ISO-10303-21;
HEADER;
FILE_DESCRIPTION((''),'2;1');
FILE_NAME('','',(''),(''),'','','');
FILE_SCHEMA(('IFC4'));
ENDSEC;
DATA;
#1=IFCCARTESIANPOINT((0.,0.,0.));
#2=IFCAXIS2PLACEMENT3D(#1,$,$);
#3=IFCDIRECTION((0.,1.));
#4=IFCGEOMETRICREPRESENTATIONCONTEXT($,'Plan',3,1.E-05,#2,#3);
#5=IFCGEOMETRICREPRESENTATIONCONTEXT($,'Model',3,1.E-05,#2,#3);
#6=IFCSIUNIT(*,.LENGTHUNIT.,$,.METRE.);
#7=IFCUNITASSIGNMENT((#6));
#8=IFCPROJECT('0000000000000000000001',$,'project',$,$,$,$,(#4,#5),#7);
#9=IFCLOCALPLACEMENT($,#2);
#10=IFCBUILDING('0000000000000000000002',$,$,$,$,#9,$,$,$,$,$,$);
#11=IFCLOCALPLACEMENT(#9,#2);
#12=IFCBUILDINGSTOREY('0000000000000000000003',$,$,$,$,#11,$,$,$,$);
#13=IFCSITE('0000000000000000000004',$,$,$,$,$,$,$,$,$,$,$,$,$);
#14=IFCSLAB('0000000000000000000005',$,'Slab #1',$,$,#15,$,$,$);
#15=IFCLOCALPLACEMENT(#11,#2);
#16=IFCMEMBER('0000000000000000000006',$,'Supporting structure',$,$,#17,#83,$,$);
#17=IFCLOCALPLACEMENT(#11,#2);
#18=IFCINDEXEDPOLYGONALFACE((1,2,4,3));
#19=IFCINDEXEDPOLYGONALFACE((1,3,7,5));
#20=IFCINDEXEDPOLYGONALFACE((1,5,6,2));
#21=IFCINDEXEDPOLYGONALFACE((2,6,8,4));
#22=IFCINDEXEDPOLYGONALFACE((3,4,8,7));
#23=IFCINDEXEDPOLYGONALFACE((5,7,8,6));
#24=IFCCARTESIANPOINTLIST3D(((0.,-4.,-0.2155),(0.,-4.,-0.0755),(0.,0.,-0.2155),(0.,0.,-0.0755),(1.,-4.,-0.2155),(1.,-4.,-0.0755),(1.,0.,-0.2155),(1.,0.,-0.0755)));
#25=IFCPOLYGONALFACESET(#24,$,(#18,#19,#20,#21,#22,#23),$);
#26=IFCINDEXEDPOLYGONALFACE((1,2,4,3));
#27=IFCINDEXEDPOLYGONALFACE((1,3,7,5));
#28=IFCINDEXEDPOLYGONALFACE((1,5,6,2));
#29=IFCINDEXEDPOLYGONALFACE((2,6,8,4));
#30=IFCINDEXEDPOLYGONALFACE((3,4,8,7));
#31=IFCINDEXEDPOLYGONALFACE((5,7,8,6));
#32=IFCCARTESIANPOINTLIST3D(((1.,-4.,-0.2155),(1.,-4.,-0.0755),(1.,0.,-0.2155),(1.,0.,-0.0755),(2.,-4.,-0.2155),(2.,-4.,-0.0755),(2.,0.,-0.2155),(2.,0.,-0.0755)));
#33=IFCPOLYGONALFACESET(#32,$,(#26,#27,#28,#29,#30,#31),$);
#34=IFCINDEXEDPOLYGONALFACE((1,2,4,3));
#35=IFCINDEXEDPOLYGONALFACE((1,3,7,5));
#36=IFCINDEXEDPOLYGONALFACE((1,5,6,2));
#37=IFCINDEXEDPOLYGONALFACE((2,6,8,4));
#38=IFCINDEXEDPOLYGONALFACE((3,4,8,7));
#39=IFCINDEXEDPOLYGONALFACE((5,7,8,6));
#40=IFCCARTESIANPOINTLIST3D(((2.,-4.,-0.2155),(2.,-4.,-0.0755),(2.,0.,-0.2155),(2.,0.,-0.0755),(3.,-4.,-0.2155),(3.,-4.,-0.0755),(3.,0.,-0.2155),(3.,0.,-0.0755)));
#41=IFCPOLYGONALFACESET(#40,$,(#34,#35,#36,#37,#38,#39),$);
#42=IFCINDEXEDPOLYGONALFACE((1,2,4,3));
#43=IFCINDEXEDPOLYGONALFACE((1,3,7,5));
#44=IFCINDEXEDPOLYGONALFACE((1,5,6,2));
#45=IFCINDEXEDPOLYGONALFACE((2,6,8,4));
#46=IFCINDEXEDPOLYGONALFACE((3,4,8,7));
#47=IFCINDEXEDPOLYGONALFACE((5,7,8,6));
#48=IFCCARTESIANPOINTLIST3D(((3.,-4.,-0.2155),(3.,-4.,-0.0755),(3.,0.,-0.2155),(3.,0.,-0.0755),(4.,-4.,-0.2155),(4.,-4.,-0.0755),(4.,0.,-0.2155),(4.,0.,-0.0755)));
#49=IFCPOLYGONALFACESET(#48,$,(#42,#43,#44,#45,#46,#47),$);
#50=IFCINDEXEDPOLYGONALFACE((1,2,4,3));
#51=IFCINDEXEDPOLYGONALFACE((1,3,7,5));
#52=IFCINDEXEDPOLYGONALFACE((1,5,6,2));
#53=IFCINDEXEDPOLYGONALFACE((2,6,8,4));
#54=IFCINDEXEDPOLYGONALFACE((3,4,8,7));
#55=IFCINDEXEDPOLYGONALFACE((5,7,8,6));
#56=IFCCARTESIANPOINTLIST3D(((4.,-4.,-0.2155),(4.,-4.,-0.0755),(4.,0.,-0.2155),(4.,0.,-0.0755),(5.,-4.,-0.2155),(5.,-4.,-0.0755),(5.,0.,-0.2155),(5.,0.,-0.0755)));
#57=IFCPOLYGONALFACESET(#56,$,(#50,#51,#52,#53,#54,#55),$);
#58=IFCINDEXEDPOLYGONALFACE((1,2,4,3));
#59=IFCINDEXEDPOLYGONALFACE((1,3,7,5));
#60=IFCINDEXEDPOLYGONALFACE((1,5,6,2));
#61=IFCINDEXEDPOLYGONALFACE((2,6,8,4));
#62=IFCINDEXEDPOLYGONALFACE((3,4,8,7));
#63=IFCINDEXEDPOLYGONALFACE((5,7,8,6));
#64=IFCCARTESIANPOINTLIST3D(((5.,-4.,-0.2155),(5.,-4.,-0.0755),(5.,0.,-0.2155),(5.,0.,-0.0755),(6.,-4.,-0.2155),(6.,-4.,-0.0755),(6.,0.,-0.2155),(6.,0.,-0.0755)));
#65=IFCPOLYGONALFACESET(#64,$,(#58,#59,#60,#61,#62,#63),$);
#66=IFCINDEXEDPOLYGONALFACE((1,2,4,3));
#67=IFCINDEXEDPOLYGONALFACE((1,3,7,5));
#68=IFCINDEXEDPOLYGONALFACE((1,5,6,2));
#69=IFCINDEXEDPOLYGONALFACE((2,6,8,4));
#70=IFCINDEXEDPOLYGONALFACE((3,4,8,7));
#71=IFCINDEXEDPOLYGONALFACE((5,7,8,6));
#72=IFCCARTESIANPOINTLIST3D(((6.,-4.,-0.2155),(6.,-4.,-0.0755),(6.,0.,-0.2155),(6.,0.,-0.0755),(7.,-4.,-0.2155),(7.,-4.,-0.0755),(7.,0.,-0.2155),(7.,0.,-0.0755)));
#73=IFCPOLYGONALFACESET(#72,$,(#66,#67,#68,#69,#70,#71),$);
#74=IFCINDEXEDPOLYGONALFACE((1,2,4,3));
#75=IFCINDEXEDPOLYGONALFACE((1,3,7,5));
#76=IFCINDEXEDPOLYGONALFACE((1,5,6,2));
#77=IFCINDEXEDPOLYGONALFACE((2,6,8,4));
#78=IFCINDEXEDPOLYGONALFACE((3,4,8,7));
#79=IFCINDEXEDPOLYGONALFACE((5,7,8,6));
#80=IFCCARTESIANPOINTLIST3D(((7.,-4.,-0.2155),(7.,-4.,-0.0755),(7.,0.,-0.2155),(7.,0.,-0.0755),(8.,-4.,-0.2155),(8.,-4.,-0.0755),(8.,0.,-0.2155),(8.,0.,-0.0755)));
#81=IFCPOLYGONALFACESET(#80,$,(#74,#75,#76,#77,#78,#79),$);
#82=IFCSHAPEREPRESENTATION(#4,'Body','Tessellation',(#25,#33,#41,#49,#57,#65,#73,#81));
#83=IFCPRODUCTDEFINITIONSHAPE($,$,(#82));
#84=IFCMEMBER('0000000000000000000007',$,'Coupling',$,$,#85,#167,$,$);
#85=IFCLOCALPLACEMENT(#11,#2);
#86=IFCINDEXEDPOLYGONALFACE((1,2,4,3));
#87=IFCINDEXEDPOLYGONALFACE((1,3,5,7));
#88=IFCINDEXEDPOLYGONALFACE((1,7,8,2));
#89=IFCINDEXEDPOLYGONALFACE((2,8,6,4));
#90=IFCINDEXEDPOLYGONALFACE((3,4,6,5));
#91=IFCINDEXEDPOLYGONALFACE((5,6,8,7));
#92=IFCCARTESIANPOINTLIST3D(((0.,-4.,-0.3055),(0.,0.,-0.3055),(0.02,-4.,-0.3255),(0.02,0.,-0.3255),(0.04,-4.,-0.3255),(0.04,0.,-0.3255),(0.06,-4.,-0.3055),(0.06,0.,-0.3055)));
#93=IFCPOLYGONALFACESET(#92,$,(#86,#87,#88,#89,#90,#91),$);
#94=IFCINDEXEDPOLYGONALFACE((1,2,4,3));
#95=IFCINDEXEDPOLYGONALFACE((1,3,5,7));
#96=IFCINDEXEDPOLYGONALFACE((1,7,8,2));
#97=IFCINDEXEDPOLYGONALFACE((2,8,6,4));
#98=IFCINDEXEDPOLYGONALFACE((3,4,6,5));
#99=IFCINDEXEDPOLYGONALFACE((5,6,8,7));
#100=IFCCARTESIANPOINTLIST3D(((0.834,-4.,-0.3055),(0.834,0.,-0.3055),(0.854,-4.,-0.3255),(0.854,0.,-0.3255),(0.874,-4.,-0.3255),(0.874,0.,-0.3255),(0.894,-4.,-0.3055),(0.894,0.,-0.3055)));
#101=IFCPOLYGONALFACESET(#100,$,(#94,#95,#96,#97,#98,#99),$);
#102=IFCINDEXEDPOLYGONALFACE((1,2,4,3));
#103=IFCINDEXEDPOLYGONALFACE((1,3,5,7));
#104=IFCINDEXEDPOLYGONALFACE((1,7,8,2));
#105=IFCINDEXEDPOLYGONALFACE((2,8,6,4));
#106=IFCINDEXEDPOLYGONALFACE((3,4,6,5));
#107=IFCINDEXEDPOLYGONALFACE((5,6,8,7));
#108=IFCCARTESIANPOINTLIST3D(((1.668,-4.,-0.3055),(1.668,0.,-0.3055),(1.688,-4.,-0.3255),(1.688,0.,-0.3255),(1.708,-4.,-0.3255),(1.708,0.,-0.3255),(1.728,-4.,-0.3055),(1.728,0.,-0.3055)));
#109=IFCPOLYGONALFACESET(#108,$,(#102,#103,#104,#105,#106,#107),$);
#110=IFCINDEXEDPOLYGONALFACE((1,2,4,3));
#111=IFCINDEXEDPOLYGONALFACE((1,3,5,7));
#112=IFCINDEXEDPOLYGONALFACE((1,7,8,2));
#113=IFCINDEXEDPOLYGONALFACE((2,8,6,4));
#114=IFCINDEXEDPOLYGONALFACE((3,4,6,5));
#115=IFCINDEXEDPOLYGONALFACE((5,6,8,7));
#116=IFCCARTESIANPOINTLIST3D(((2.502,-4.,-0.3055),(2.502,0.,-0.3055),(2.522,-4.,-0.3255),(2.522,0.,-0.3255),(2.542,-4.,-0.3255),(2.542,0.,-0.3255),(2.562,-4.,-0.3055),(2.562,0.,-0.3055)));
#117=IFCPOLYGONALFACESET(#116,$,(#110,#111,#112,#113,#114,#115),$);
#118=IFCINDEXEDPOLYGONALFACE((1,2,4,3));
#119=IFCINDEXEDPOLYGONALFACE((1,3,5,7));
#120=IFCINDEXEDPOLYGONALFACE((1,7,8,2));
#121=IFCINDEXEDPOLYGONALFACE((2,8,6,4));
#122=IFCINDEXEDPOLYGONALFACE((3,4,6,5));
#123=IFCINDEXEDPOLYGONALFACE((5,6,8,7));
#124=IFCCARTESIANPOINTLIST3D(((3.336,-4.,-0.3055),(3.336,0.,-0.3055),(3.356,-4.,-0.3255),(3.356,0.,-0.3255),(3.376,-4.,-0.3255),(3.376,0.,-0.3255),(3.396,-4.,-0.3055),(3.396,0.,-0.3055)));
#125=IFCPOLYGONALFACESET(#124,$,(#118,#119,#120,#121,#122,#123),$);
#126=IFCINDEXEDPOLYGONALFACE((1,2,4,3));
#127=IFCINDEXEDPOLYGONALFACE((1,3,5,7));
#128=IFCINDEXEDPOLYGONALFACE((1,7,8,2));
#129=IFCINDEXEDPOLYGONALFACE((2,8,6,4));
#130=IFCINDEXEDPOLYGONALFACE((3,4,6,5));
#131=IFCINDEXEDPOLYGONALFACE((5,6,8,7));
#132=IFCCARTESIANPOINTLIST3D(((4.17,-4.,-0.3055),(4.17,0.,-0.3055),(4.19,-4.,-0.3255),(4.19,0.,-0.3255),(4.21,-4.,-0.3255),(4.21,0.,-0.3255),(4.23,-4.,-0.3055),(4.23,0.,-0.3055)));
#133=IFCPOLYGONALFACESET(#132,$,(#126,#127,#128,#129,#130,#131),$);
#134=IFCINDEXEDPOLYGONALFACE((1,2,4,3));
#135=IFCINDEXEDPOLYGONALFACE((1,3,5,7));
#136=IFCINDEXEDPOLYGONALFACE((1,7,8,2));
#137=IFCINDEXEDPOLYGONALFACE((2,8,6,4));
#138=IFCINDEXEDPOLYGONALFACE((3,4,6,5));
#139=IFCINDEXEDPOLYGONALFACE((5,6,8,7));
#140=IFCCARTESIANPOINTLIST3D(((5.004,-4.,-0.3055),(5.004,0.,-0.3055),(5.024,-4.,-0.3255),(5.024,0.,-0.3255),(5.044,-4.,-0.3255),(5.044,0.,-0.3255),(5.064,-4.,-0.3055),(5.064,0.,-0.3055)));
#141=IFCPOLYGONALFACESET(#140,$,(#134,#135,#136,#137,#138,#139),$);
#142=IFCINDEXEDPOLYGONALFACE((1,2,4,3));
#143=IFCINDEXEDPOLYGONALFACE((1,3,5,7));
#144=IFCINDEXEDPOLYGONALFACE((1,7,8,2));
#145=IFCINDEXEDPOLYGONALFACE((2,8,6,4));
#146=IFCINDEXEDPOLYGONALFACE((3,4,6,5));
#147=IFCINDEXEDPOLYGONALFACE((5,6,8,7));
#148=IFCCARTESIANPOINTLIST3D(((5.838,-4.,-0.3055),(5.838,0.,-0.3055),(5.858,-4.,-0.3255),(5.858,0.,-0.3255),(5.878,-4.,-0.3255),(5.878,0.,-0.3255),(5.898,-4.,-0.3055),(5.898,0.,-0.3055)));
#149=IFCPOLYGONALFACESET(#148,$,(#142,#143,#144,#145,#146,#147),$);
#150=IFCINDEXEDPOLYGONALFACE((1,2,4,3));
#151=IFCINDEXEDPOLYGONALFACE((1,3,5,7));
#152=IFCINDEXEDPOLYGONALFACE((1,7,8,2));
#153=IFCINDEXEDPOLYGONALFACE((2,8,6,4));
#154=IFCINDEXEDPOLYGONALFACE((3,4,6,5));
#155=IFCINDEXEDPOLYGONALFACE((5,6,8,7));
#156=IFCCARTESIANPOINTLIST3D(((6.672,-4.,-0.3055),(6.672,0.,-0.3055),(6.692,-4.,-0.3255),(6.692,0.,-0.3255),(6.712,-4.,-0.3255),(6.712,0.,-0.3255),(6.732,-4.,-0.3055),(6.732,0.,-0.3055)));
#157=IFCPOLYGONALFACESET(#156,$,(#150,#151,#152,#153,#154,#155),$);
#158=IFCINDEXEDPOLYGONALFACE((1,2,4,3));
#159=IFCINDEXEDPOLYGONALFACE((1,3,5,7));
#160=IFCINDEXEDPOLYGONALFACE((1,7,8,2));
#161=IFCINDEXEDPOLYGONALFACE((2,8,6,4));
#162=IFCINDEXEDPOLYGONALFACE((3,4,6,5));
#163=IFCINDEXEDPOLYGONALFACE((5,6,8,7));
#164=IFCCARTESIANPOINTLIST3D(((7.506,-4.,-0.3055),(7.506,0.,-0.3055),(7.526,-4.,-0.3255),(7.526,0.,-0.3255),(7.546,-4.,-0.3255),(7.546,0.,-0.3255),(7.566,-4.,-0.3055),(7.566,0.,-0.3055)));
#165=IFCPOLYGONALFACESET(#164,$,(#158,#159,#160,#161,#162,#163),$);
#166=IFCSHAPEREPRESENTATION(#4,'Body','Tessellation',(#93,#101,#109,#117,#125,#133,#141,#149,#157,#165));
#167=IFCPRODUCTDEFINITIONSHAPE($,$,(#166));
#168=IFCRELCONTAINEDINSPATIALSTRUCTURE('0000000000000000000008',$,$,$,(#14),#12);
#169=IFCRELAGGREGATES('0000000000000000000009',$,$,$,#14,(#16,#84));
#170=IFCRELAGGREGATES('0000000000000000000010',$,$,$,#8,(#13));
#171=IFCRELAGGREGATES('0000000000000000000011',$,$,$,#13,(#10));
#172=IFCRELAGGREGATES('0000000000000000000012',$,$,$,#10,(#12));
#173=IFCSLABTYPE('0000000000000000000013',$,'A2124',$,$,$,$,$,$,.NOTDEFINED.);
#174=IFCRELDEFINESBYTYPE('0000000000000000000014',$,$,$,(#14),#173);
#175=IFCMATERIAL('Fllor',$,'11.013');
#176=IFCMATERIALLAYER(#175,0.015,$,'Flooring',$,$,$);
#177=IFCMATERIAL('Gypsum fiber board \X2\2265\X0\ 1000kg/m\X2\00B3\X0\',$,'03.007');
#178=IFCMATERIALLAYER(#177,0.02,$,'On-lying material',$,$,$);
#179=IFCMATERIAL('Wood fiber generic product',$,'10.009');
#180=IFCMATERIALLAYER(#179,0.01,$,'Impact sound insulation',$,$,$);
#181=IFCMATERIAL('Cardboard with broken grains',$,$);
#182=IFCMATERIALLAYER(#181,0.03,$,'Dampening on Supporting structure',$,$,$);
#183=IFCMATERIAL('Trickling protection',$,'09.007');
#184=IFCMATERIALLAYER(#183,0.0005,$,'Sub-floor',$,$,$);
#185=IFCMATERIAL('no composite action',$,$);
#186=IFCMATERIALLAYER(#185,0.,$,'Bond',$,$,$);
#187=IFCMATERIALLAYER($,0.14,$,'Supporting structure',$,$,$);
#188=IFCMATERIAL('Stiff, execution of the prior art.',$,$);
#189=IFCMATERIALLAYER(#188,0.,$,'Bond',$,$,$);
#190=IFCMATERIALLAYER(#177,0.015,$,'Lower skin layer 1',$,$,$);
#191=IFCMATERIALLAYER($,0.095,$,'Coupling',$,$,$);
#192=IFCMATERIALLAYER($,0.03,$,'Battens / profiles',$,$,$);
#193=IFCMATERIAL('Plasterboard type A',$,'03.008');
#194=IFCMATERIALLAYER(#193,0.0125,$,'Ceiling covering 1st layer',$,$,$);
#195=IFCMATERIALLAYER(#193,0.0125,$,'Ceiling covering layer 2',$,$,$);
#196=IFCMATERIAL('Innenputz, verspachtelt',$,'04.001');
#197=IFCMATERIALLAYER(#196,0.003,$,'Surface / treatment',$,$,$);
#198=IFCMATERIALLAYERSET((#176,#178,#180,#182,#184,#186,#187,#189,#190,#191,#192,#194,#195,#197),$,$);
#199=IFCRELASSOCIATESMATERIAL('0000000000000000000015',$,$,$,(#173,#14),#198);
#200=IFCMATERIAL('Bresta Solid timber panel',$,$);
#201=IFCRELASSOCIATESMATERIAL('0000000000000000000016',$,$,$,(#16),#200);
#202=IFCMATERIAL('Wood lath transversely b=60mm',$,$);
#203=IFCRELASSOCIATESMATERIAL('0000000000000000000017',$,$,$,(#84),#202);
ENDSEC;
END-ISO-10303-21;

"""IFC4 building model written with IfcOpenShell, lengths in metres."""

from ifc_helpers import new_model, si_unit, direction, frame, frame_2d, origin, place, context, project, spatial, polyline, rectangle, outline, extrude, material, layer, layer_set, type_object, element, aggregate, save


model = new_model("IFC4")

# Units and contexts
plan_context = context("Plan", 3, precision=1e-05, world=origin(), true_north=direction((0.0, 1.0)))
model_context = context("Model", 3, precision=1e-05, world=origin(), true_north=direction((0.0, 1.0)))
ifc_project = project(units=[si_unit("LENGTHUNIT", "METRE")], contexts=[plan_context, model_context])

# Site, building, storey
site = spatial("IfcSite", under=ifc_project)
building_placement = place(None, origin())
building = spatial("IfcBuilding", under=site, at=building_placement)
storey_placement = place(building_placement, origin())
storey = spatial("IfcBuildingStorey", under=building, at=storey_placement)

# Slab, members
ifc_material_1 = material(Name="Fllor", Category="11.013")
ifc_layer_1 = layer(ifc_material_1, 0.015, Name="Flooring")
ifc_material_2 = material(Name="Gypsum fiber board ≥ 1000kg/m³", Category="03.007")
ifc_layer_2 = layer(ifc_material_2, 0.02, Name="On-lying material")
ifc_material_3 = material(Name="Wood fiber generic product", Category="10.009")
ifc_layer_3 = layer(ifc_material_3, 0.01, Name="Impact sound insulation")
ifc_material_4 = material(Name="Cardboard with broken grains")
ifc_layer_4 = layer(ifc_material_4, 0.03, Name="Dampening on Supporting structure")
ifc_material_5 = material(Name="Trickling protection", Category="09.007")
ifc_layer_5 = layer(ifc_material_5, 0.0005, Name="Sub-floor")
ifc_material_6 = material(Name="no composite action")
ifc_layer_6 = layer(ifc_material_6, 0.0, Name="Bond")
ifc_layer_7 = layer(None, 0.14, Name="Supporting structure")
ifc_material_7 = material(Name="Stiff, execution of the prior art.")
ifc_layer_8 = layer(ifc_material_7, 0.0, Name="Bond")
ifc_layer_9 = layer(ifc_material_2, 0.015, Name="Lower skin layer 1")
ifc_layer_10 = layer(None, 0.095, Name="Coupling")
ifc_layer_11 = layer(None, 0.03, Name="Battens / profiles")
ifc_material_8 = material(Name="Plasterboard type A", Category="03.008")
ifc_layer_12 = layer(ifc_material_8, 0.0125, Name="Ceiling covering 1st layer")
ifc_layer_13 = layer(ifc_material_8, 0.0125, Name="Ceiling covering layer 2")
ifc_material_9 = material(Name="Innenputz, verspachtelt", Category="04.001")
ifc_layer_14 = layer(ifc_material_9, 0.003, Name="Surface / treatment")
ifc_layer_set = layer_set([ifc_layer_1, ifc_layer_2, ifc_layer_3, ifc_layer_4, ifc_layer_5, ifc_layer_6, ifc_layer_7, ifc_layer_8, ifc_layer_9, ifc_layer_10, ifc_layer_11, ifc_layer_12, ifc_layer_13, ifc_layer_14])
slab_type = type_object("IfcSlabType", Name="A2124", PredefinedType="NOTDEFINED", material=ifc_layer_set)
slab_placement = place(None, frame((0.0, 0.0, 0.0), z_axis=(0.0, 0.0, -1.0), x_axis=(1.0, 0.0, 0.0)))
slab = element("IfcSlab", 1, at=slab_placement, inside=storey, type_object=slab_type, material=ifc_layer_set, Name="Slab #1")
ifc_material_10 = material(Name="Bresta Solid timber panel")
member_1_placement = place(slab_placement, origin())
member_1 = element("IfcMember", 2, at=member_1_placement, material=ifc_material_10, Name="Supporting structure", context=plan_context, shape_type="SweptSolid", body=[
    extrude(rectangle(XDim=1.0, YDim=0.14, at=frame_2d((0.5, 0.07), x_axis=(1.0, 0.0))), frame((0.0, 4.0, 0.0755), z_axis=(0.0, -1.0, 0.0), x_axis=(1.0, 0.0, 0.0)), (0.0, 0.0, 1.0), 4.0),
    extrude(rectangle(XDim=1.0, YDim=0.14, at=frame_2d((0.5, 0.07), x_axis=(1.0, 0.0))), frame((1.0, 4.0, 0.0755), z_axis=(0.0, -1.0, 0.0), x_axis=(1.0, 0.0, 0.0)), (0.0, 0.0, 1.0), 4.0),
    extrude(rectangle(XDim=1.0, YDim=0.14, at=frame_2d((0.5, 0.07), x_axis=(1.0, 0.0))), frame((2.0, 4.0, 0.0755), z_axis=(0.0, -1.0, 0.0), x_axis=(1.0, 0.0, 0.0)), (0.0, 0.0, 1.0), 4.0),
    extrude(rectangle(XDim=1.0, YDim=0.14, at=frame_2d((0.5, 0.07), x_axis=(1.0, 0.0))), frame((3.0, 4.0, 0.0755), z_axis=(0.0, -1.0, 0.0), x_axis=(1.0, 0.0, 0.0)), (0.0, 0.0, 1.0), 4.0),
    extrude(rectangle(XDim=1.0, YDim=0.14, at=frame_2d((0.5, 0.07), x_axis=(1.0, 0.0))), frame((4.0, 4.0, 0.0755), z_axis=(0.0, -1.0, 0.0), x_axis=(1.0, 0.0, 0.0)), (0.0, 0.0, 1.0), 4.0),
    extrude(rectangle(XDim=1.0, YDim=0.14, at=frame_2d((0.5, 0.07), x_axis=(1.0, 0.0))), frame((5.0, 4.0, 0.0755), z_axis=(0.0, -1.0, 0.0), x_axis=(1.0, 0.0, 0.0)), (0.0, 0.0, 1.0), 4.0),
    extrude(rectangle(XDim=1.0, YDim=0.14, at=frame_2d((0.5, 0.07), x_axis=(1.0, 0.0))), frame((6.0, 4.0, 0.0755), z_axis=(0.0, -1.0, 0.0), x_axis=(1.0, 0.0, 0.0)), (0.0, 0.0, 1.0), 4.0),
    extrude(rectangle(XDim=1.0, YDim=0.14, at=frame_2d((0.5, 0.07), x_axis=(1.0, 0.0))), frame((7.0, 4.0, 0.0755), z_axis=(0.0, -1.0, 0.0), x_axis=(1.0, 0.0, 0.0)), (0.0, 0.0, 1.0), 4.0),
])
ifc_material_11 = material(Name="Wood lath transversely b=60mm")
member_2_placement = place(slab_placement, origin())
member_2 = element("IfcMember", 3, at=member_2_placement, material=ifc_material_11, Name="Coupling", context=plan_context, shape_type="SweptSolid", body=[
    extrude(outline(polyline([(0.0, 0.0), (0.06, 0.0), (0.04, 0.02), (0.02, 0.02), (0.0, 0.0)])), frame((0.0, 4.0, 0.3055), z_axis=(0.0, -1.0, 0.0), x_axis=(1.0, 0.0, 0.0)), (0.0, 0.0, 1.0), 4.0),
    extrude(outline(polyline([(0.0, 0.0), (0.06, 0.0), (0.04, 0.02), (0.02, 0.02), (0.0, 0.0)])), frame((0.834, 4.0, 0.3055), z_axis=(0.0, -1.0, 0.0), x_axis=(1.0, 0.0, 0.0)), (0.0, 0.0, 1.0), 4.0),
    extrude(outline(polyline([(0.0, 0.0), (0.06, 0.0), (0.04, 0.02), (0.02, 0.02), (0.0, 0.0)])), frame((1.668, 4.0, 0.3055), z_axis=(0.0, -1.0, 0.0), x_axis=(1.0, 0.0, 0.0)), (0.0, 0.0, 1.0), 4.0),
    extrude(outline(polyline([(0.0, 0.0), (0.06, 0.0), (0.04, 0.02), (0.02, 0.02), (0.0, 0.0)])), frame((2.502, 4.0, 0.3055), z_axis=(0.0, -1.0, 0.0), x_axis=(1.0, 0.0, 0.0)), (0.0, 0.0, 1.0), 4.0),
    extrude(outline(polyline([(0.0, 0.0), (0.06, 0.0), (0.04, 0.02), (0.02, 0.02), (0.0, 0.0)])), frame((3.336, 4.0, 0.3055), z_axis=(0.0, -1.0, 0.0), x_axis=(1.0, 0.0, 0.0)), (0.0, 0.0, 1.0), 4.0),
    extrude(outline(polyline([(0.0, 0.0), (0.06, 0.0), (0.04, 0.02), (0.02, 0.02), (0.0, 0.0)])), frame((4.17, 4.0, 0.3055), z_axis=(0.0, -1.0, 0.0), x_axis=(1.0, 0.0, 0.0)), (0.0, 0.0, 1.0), 4.0),
    extrude(outline(polyline([(0.0, 0.0), (0.06, 0.0), (0.04, 0.02), (0.02, 0.02), (0.0, 0.0)])), frame((5.004, 4.0, 0.3055), z_axis=(0.0, -1.0, 0.0), x_axis=(1.0, 0.0, 0.0)), (0.0, 0.0, 1.0), 4.0),
    extrude(outline(polyline([(0.0, 0.0), (0.06, 0.0), (0.04, 0.02), (0.02, 0.02), (0.0, 0.0)])), frame((5.838, 4.0, 0.3055), z_axis=(0.0, -1.0, 0.0), x_axis=(1.0, 0.0, 0.0)), (0.0, 0.0, 1.0), 4.0),
    extrude(outline(polyline([(0.0, 0.0), (0.06, 0.0), (0.04, 0.02), (0.02, 0.02), (0.0, 0.0)])), frame((6.672, 4.0, 0.3055), z_axis=(0.0, -1.0, 0.0), x_axis=(1.0, 0.0, 0.0)), (0.0, 0.0, 1.0), 4.0),
    extrude(outline(polyline([(0.0, 0.0), (0.06, 0.0), (0.04, 0.02), (0.02, 0.02), (0.0, 0.0)])), frame((7.506, 4.0, 0.3055), z_axis=(0.0, -1.0, 0.0), x_axis=(1.0, 0.0, 0.0)), (0.0, 0.0, 1.0), 4.0),
])
aggregate(slab, [member_1, member_2])

save(model, "model.ifc")
